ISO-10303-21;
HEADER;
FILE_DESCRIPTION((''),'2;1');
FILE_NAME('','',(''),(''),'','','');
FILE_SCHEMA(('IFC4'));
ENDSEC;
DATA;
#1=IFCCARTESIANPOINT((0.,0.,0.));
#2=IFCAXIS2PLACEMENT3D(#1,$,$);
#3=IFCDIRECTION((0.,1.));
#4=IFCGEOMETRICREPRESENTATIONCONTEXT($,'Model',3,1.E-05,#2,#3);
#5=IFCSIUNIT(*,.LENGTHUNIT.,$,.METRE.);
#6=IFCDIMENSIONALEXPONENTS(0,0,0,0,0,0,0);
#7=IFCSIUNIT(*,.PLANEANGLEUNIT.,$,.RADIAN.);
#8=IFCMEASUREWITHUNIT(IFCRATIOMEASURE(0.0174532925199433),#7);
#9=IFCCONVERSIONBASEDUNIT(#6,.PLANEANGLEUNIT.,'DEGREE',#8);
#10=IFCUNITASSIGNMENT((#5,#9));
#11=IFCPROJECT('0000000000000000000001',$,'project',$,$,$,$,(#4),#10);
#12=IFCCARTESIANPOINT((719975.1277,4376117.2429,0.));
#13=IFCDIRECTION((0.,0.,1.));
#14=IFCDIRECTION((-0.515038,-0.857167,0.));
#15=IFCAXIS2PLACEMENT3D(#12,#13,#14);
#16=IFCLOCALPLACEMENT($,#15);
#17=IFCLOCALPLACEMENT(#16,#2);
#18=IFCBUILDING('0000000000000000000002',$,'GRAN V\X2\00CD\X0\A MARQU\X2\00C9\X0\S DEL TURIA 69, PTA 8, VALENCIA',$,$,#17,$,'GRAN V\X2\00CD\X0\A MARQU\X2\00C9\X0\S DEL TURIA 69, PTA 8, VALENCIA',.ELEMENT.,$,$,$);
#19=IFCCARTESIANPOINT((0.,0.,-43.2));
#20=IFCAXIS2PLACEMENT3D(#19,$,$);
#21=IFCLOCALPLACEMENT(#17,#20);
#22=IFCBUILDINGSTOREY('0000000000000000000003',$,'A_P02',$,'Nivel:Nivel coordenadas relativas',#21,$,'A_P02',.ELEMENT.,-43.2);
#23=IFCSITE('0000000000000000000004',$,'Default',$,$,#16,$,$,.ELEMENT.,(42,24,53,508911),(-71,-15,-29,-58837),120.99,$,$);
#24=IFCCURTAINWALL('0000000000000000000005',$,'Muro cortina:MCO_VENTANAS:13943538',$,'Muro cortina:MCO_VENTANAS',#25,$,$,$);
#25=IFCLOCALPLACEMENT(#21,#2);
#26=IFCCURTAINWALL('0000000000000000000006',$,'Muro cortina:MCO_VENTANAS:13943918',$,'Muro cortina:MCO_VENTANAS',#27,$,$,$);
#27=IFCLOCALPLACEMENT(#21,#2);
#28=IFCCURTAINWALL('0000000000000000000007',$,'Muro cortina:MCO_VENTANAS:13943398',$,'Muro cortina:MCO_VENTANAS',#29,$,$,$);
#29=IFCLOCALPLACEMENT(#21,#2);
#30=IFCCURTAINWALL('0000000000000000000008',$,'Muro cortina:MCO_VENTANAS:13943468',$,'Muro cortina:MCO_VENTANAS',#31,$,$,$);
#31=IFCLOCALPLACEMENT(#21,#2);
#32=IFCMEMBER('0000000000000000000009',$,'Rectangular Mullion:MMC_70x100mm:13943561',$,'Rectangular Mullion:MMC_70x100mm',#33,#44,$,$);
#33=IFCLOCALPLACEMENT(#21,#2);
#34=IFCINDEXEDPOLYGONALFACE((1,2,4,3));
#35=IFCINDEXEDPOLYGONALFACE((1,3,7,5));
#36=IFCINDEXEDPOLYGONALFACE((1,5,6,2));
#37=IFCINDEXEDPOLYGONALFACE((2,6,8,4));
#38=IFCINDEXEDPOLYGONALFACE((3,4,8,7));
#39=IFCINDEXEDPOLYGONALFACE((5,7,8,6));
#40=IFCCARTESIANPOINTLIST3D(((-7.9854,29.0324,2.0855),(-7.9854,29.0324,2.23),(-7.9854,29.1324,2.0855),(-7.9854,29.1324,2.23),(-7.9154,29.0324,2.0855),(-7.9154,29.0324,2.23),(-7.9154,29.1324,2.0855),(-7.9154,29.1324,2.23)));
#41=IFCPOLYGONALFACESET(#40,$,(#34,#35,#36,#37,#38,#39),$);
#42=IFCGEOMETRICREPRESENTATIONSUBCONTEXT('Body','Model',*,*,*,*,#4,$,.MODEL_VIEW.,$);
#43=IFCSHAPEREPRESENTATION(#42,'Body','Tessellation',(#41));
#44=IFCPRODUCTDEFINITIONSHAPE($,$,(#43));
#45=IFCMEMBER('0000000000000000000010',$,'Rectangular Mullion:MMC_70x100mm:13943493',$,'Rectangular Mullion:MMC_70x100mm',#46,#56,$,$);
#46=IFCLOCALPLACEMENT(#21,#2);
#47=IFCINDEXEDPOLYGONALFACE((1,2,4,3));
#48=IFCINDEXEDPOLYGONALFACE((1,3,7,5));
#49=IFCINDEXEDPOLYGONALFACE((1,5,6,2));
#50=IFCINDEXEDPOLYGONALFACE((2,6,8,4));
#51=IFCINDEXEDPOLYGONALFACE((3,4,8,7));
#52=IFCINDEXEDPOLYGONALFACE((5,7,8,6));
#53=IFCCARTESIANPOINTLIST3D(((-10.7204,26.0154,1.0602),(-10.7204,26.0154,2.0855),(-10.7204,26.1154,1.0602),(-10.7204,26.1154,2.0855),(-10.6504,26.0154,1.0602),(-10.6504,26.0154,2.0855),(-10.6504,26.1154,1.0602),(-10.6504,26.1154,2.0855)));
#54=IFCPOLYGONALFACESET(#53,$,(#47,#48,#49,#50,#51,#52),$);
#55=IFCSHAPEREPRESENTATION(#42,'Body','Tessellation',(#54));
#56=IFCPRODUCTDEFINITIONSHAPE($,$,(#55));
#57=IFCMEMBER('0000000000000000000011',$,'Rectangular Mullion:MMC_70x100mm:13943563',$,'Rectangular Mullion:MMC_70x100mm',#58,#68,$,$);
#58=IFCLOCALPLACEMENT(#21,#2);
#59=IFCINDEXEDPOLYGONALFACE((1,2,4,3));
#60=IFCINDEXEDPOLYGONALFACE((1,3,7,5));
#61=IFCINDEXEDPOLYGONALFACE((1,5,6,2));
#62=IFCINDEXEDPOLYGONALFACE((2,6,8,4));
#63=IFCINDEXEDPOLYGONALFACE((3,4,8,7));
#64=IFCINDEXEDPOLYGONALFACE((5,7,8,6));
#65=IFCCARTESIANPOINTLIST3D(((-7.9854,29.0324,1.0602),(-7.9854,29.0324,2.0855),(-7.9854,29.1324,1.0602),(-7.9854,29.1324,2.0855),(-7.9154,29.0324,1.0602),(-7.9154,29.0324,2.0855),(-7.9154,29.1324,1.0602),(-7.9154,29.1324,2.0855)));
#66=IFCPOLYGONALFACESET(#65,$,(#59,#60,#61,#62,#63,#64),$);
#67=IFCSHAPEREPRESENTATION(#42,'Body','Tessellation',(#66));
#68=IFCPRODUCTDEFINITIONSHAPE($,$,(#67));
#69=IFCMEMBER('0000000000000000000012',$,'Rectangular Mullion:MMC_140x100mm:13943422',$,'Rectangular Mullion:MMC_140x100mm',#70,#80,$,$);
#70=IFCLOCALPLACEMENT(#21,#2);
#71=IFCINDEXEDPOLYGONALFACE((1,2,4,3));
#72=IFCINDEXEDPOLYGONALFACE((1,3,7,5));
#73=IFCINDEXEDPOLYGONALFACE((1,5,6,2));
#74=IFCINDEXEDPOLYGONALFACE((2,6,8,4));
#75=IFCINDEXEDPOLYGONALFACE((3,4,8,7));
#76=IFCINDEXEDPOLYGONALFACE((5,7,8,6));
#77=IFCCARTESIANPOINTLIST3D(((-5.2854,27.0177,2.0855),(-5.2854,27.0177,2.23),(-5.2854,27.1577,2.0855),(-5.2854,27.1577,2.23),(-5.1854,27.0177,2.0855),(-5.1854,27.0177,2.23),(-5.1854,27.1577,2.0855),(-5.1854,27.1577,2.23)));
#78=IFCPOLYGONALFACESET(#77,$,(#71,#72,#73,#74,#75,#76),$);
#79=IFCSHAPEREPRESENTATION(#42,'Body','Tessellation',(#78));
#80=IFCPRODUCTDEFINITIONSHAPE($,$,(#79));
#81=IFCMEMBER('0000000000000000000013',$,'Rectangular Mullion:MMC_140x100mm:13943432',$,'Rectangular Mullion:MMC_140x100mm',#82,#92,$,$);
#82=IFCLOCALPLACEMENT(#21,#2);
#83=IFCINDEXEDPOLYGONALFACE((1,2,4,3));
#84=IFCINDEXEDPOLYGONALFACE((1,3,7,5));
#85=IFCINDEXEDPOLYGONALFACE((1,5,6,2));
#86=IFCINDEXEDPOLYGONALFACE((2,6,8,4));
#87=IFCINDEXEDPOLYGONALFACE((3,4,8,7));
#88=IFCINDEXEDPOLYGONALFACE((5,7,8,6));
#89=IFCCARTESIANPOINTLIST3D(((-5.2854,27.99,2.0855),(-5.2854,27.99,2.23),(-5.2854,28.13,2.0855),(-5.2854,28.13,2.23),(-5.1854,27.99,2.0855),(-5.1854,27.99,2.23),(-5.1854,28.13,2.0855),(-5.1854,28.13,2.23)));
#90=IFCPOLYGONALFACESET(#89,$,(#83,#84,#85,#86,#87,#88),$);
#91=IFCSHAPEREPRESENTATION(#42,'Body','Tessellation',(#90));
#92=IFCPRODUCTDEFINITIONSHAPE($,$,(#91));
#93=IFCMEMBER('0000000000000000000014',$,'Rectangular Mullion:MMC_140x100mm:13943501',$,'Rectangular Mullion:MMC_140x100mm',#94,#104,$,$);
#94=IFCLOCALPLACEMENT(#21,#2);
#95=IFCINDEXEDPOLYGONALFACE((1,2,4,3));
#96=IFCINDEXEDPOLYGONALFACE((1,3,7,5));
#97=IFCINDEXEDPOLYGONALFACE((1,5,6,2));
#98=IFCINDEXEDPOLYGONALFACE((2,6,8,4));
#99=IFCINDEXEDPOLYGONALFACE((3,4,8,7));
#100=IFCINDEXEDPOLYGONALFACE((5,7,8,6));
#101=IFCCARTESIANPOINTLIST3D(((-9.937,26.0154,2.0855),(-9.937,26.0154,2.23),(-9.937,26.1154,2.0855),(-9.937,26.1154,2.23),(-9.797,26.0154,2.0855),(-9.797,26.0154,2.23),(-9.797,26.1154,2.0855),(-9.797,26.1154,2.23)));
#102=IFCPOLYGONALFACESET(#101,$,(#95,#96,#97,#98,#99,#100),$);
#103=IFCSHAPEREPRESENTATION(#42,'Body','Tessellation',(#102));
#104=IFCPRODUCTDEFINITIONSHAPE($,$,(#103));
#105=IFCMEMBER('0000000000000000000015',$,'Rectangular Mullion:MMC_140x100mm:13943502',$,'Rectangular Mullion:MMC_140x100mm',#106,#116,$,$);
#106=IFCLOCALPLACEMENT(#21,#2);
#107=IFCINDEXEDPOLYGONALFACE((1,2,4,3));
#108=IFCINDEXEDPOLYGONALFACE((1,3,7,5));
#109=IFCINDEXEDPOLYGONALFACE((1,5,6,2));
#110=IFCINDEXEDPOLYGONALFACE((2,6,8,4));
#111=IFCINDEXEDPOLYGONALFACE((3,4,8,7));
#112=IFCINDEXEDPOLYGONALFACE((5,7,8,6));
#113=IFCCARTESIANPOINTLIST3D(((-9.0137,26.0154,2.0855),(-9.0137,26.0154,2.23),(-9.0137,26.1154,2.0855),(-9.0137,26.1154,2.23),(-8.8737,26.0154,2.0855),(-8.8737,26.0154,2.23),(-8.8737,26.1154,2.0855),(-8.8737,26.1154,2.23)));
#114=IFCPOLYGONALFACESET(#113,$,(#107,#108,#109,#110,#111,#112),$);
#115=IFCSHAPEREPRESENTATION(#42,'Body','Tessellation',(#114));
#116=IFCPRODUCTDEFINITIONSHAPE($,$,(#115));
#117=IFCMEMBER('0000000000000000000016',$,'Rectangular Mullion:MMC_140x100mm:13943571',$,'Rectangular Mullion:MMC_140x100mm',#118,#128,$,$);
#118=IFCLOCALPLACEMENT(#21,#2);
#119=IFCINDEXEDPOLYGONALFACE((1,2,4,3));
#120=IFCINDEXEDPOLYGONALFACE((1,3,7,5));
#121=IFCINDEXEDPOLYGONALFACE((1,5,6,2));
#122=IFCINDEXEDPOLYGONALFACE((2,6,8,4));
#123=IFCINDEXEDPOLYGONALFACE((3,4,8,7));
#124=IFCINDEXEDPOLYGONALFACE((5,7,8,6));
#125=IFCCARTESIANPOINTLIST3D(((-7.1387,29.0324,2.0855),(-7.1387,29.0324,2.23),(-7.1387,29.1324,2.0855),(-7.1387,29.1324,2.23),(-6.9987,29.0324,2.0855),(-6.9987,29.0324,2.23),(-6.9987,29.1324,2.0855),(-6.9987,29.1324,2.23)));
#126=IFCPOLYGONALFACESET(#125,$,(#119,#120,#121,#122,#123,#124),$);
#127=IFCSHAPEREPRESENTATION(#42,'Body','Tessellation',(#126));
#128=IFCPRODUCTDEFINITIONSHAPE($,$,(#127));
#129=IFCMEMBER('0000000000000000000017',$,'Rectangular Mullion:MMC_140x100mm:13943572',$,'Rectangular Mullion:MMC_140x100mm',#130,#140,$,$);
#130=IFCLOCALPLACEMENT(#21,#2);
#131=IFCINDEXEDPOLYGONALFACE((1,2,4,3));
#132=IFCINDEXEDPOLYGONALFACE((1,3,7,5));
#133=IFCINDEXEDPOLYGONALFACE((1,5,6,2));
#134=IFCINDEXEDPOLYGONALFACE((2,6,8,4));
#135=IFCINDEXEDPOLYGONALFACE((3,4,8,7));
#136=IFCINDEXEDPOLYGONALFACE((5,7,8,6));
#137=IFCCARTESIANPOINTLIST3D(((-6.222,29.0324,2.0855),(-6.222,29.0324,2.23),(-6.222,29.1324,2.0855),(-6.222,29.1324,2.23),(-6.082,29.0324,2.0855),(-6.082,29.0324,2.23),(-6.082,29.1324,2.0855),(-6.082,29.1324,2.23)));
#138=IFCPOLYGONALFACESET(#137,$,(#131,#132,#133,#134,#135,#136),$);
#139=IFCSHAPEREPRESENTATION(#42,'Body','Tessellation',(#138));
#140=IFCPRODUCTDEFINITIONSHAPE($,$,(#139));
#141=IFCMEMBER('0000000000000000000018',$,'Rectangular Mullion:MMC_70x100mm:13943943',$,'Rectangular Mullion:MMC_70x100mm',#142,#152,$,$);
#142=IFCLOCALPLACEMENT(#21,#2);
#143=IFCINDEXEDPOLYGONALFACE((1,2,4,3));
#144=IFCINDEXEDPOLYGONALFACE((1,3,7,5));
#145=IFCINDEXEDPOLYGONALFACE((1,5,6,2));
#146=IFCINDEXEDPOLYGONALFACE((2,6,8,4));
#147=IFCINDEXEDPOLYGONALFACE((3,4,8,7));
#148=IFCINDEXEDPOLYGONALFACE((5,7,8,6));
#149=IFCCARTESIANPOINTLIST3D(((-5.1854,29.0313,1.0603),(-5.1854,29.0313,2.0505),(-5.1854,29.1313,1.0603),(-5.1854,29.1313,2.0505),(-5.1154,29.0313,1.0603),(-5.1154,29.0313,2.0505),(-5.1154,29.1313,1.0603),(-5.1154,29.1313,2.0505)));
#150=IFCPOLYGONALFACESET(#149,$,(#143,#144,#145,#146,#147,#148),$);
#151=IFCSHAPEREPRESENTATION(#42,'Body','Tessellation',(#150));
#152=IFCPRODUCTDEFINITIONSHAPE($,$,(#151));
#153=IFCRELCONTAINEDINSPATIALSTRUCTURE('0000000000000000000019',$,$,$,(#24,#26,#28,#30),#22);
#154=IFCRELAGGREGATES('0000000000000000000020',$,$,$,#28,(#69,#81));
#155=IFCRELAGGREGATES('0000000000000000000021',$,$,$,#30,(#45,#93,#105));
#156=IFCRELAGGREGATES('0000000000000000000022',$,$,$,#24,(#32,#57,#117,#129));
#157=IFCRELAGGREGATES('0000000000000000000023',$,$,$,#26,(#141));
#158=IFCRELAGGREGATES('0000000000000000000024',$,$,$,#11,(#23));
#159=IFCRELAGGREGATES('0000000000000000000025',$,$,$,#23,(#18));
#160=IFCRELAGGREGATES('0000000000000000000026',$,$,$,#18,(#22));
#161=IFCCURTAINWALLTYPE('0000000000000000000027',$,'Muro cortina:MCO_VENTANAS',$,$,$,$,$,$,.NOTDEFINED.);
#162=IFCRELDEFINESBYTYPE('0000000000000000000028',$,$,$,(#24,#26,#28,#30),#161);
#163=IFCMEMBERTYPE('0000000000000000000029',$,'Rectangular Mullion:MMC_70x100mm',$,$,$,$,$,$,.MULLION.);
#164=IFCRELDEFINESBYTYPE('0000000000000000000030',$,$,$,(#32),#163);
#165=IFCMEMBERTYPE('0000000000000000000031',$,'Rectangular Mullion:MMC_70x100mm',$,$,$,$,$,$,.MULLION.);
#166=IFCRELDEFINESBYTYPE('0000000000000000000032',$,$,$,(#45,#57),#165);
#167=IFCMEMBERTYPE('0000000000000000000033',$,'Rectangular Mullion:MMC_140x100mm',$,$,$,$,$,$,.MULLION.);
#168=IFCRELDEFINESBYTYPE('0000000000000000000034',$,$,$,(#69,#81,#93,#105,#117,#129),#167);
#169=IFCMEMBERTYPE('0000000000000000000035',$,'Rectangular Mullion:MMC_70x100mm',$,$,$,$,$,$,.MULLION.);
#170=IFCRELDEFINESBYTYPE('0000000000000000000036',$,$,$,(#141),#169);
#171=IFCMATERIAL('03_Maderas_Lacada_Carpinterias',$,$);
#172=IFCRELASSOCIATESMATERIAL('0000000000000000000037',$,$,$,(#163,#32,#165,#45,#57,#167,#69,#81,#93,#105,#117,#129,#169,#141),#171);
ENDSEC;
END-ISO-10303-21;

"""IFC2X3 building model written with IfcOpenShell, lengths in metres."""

from ifc_helpers import new_model, entity, si_unit, converted_unit, direction, frame, origin, origin_2d_with_axis, place, context, subcontext, project, spatial, rectangle, extrude, source, transform, mapped, material, type_object, type_shapes, element, aggregate, save


model = new_model("IFC2X3")

# Units and contexts
model_context = context("Model", 3, precision=1e-05, world=origin(), true_north=direction((0.0, 1.0)))
body_context = subcontext(model_context, "Body", "Model", "MODEL_VIEW")
ifc_project = project(units=[si_unit("LENGTHUNIT", "METRE"), converted_unit("PLANEANGLEUNIT", "DEGREE", entity("IfcRatioMeasure", 0.0174532925199433), si_unit("PLANEANGLEUNIT", "RADIAN"), dimensions=[0, 0, 0, 0, 0, 0, 0])], contexts=[model_context])

# Site, building, storey
site_placement = place(None, frame((719975.1277, 4376117.2429, 0.0), z_axis=(0.0, 0.0, 1.0), x_axis=(-0.515038, -0.857167, 0.0)))
site = spatial("IfcSite", under=ifc_project, at=site_placement, Name="Default", CompositionType="ELEMENT", RefLatitude=(42, 24, 53, 508911), RefLongitude=(-71, -15, -29, -58837), RefElevation=120.99)
building_placement = place(site_placement, origin())
building = spatial("IfcBuilding", under=site, at=building_placement, Name="GRAN VÍA MARQUÉS DEL TURIA 69, PTA 8, VALENCIA", LongName="GRAN VÍA MARQUÉS DEL TURIA 69, PTA 8, VALENCIA", CompositionType="ELEMENT")
storey_placement = place(building_placement, frame((0.0, 0.0, -43.2)))
storey = spatial("IfcBuildingStorey", under=building, at=storey_placement, Name="A_P02", ObjectType="Nivel:Nivel coordenadas relativas", LongName="A_P02", CompositionType="ELEMENT", Elevation=-43.2)

# Curtain wall
curtain_wall_type = type_object("IfcCurtainWallType", Name="Muro cortina:MCO_VENTANAS", PredefinedType="NOTDEFINED")
curtain_wall_1_placement = place(storey_placement, frame((0.0, 0.0, 43.2)))
curtain_wall_1 = element("IfcCurtainWall", 1, at=curtain_wall_1_placement, inside=storey, type_object=curtain_wall_type, Name="Muro cortina:MCO_VENTANAS:13943538", ObjectType="Muro cortina:MCO_VENTANAS")
ifc_material_1 = material(Name="03_Maderas_Lacada_Carpinterias")

# Curtain walls
curtain_wall_2_placement = place(storey_placement, frame((0.0, 0.0, 43.2)))
curtain_wall_2 = element("IfcCurtainWall", 2, at=curtain_wall_2_placement, inside=storey, type_object=curtain_wall_type, Name="Muro cortina:MCO_VENTANAS:13943918", ObjectType="Muro cortina:MCO_VENTANAS")
curtain_wall_3_placement = place(storey_placement, frame((0.0, 0.0, 43.2)))
curtain_wall_3 = element("IfcCurtainWall", 3, at=curtain_wall_3_placement, inside=storey, type_object=curtain_wall_type, Name="Muro cortina:MCO_VENTANAS:13943398", ObjectType="Muro cortina:MCO_VENTANAS")
curtain_wall_4_placement = place(storey_placement, frame((0.0, 0.0, 43.2)))
curtain_wall_4 = element("IfcCurtainWall", 4, at=curtain_wall_4_placement, inside=storey, type_object=curtain_wall_type, Name="Muro cortina:MCO_VENTANAS:13943468", ObjectType="Muro cortina:MCO_VENTANAS")

# Members
member_type_1 = type_object("IfcMemberType", Name="Rectangular Mullion:MMC_70x100mm", PredefinedType="MULLION", material=ifc_material_1)
shared_shape_1 = source(origin(), body_context, "Body", "SweptSolid", [
    extrude(rectangle(XDim=0.1, YDim=0.07, at=origin_2d_with_axis()), frame((-0.035, 0.0, -0.1445), z_axis=(0.0, 0.0, 1.0), x_axis=(0.0, -1.0, 0.0)), (0.0, 0.0, 1.0), 0.1445),
])
type_shapes(member_type_1, [shared_shape_1])
member_1_placement = place(storey_placement, frame((-7.9854, 29.0824, 2.23), z_axis=(0.0, 0.0, 1.0), x_axis=(-1.0, 0.0, 0.0)))
member_1 = element("IfcMember", 5, at=member_1_placement, type_object=member_type_1, material=ifc_material_1, Name="Rectangular Mullion:MMC_70x100mm:13943561", ObjectType="Rectangular Mullion:MMC_70x100mm", context=body_context, shape_type="MappedRepresentation", body=[
    mapped(shared_shape_1, transform((0.0, 0.0, 0.0), scale=1.0)),
])
member_type_2 = type_object("IfcMemberType", Name="Rectangular Mullion:MMC_70x100mm", PredefinedType="MULLION", material=ifc_material_1)
shared_shape_2 = source(origin(), body_context, "Body", "SweptSolid", [
    extrude(rectangle(XDim=0.1, YDim=0.07, at=origin_2d_with_axis()), frame((-0.035, 0.0, -1.0252), z_axis=(0.0, 0.0, 1.0), x_axis=(0.0, -1.0, 0.0)), (0.0, 0.0, 1.0), 1.0252),
])
type_shapes(member_type_2, [shared_shape_2])
member_2_placement = place(storey_placement, frame((-10.7204, 26.0654, 2.0855), z_axis=(0.0, 0.0, 1.0), x_axis=(-1.0, 0.0, 0.0)))
member_2 = element("IfcMember", 6, at=member_2_placement, type_object=member_type_2, material=ifc_material_1, Name="Rectangular Mullion:MMC_70x100mm:13943493", ObjectType="Rectangular Mullion:MMC_70x100mm", context=body_context, shape_type="MappedRepresentation", body=[
    mapped(shared_shape_2, transform((0.0, 0.0, 0.0), scale=1.0)),
])
member_3_placement = place(storey_placement, frame((-7.9854, 29.0824, 2.0855), z_axis=(0.0, 0.0, 1.0), x_axis=(-1.0, 0.0, 0.0)))
member_3 = element("IfcMember", 7, at=member_3_placement, type_object=member_type_2, material=ifc_material_1, Name="Rectangular Mullion:MMC_70x100mm:13943563", ObjectType="Rectangular Mullion:MMC_70x100mm", context=body_context, shape_type="MappedRepresentation", body=[
    mapped(shared_shape_2, transform((0.0, 0.0, 0.0), scale=1.0)),
])
member_type_3 = type_object("IfcMemberType", Name="Rectangular Mullion:MMC_140x100mm", PredefinedType="MULLION", material=ifc_material_1)
shared_shape_3 = source(origin(), body_context, "Body", "SweptSolid", [
    extrude(rectangle(XDim=0.1, YDim=0.14, at=origin_2d_with_axis()), frame((0.0, 0.0, -0.1445), z_axis=(0.0, 0.0, 1.0), x_axis=(0.0, -1.0, 0.0)), (0.0, 0.0, 1.0), 0.1445),
])
type_shapes(member_type_3, [shared_shape_3])
member_4_placement = place(storey_placement, frame((-5.2354, 27.0877, 2.0855), z_axis=(0.0, 0.0, -1.0), x_axis=(0.0, 1.0, 0.0)))
member_4 = element("IfcMember", 8, at=member_4_placement, type_object=member_type_3, material=ifc_material_1, Name="Rectangular Mullion:MMC_140x100mm:13943422", ObjectType="Rectangular Mullion:MMC_140x100mm", context=body_context, shape_type="MappedRepresentation", body=[
    mapped(shared_shape_3, transform((0.0, 0.0, 0.0), scale=1.0)),
])
member_5_placement = place(storey_placement, frame((-5.2354, 28.06, 2.0855), z_axis=(0.0, 0.0, -1.0), x_axis=(0.0, 1.0, 0.0)))
member_5 = element("IfcMember", 9, at=member_5_placement, type_object=member_type_3, material=ifc_material_1, Name="Rectangular Mullion:MMC_140x100mm:13943432", ObjectType="Rectangular Mullion:MMC_140x100mm", context=body_context, shape_type="MappedRepresentation", body=[
    mapped(shared_shape_3, transform((0.0, 0.0, 0.0), scale=1.0)),
])
aggregate(curtain_wall_3, [member_4, member_5])
member_6_placement = place(storey_placement, frame((-9.867, 26.0654, 2.0855), z_axis=(0.0, 0.0, -1.0), x_axis=(1.0, 0.0, 0.0)))
member_6 = element("IfcMember", 10, at=member_6_placement, type_object=member_type_3, material=ifc_material_1, Name="Rectangular Mullion:MMC_140x100mm:13943501", ObjectType="Rectangular Mullion:MMC_140x100mm", context=body_context, shape_type="MappedRepresentation", body=[
    mapped(shared_shape_3, transform((0.0, 0.0, 0.0), scale=1.0)),
])
member_7_placement = place(storey_placement, frame((-8.9437, 26.0654, 2.0855), z_axis=(0.0, 0.0, -1.0), x_axis=(1.0, 0.0, 0.0)))
member_7 = element("IfcMember", 11, at=member_7_placement, type_object=member_type_3, material=ifc_material_1, Name="Rectangular Mullion:MMC_140x100mm:13943502", ObjectType="Rectangular Mullion:MMC_140x100mm", context=body_context, shape_type="MappedRepresentation", body=[
    mapped(shared_shape_3, transform((0.0, 0.0, 0.0), scale=1.0)),
])
aggregate(curtain_wall_4, [member_2, member_6, member_7])
member_8_placement = place(storey_placement, frame((-7.0687, 29.0824, 2.0855), z_axis=(0.0, 0.0, -1.0), x_axis=(1.0, 0.0, 0.0)))
member_8 = element("IfcMember", 12, at=member_8_placement, type_object=member_type_3, material=ifc_material_1, Name="Rectangular Mullion:MMC_140x100mm:13943571", ObjectType="Rectangular Mullion:MMC_140x100mm", context=body_context, shape_type="MappedRepresentation", body=[
    mapped(shared_shape_3, transform((0.0, 0.0, 0.0), scale=1.0)),
])
member_9_placement = place(storey_placement, frame((-6.152, 29.0824, 2.0855), z_axis=(0.0, 0.0, -1.0), x_axis=(1.0, 0.0, 0.0)))
member_9 = element("IfcMember", 13, at=member_9_placement, type_object=member_type_3, material=ifc_material_1, Name="Rectangular Mullion:MMC_140x100mm:13943572", ObjectType="Rectangular Mullion:MMC_140x100mm", context=body_context, shape_type="MappedRepresentation", body=[
    mapped(shared_shape_3, transform((0.0, 0.0, 0.0), scale=1.0)),
])
aggregate(curtain_wall_1, [member_1, member_3, member_8, member_9])
member_type_4 = type_object("IfcMemberType", Name="Rectangular Mullion:MMC_70x100mm", PredefinedType="MULLION", material=ifc_material_1)
shared_shape_4 = source(origin(), body_context, "Body", "SweptSolid", [
    extrude(rectangle(XDim=0.1, YDim=0.07, at=origin_2d_with_axis()), frame((-0.035, 0.0, -0.9902), z_axis=(0.0, 0.0, 1.0), x_axis=(0.0, -1.0, 0.0)), (0.0, 0.0, 1.0), 0.9902),
])
type_shapes(member_type_4, [shared_shape_4])
member_10_placement = place(storey_placement, frame((-5.1854, 29.0813, 2.0505), z_axis=(0.0, 0.0, 1.0), x_axis=(-1.0, 0.0, 0.0)))
member_10 = element("IfcMember", 14, at=member_10_placement, type_object=member_type_4, material=ifc_material_1, Name="Rectangular Mullion:MMC_70x100mm:13943943", ObjectType="Rectangular Mullion:MMC_70x100mm", context=body_context, shape_type="MappedRepresentation", body=[
    mapped(shared_shape_4, transform((0.0, 0.0, 0.0), scale=1.0)),
])
aggregate(curtain_wall_2, [member_10])

save(model, "model.ifc")
